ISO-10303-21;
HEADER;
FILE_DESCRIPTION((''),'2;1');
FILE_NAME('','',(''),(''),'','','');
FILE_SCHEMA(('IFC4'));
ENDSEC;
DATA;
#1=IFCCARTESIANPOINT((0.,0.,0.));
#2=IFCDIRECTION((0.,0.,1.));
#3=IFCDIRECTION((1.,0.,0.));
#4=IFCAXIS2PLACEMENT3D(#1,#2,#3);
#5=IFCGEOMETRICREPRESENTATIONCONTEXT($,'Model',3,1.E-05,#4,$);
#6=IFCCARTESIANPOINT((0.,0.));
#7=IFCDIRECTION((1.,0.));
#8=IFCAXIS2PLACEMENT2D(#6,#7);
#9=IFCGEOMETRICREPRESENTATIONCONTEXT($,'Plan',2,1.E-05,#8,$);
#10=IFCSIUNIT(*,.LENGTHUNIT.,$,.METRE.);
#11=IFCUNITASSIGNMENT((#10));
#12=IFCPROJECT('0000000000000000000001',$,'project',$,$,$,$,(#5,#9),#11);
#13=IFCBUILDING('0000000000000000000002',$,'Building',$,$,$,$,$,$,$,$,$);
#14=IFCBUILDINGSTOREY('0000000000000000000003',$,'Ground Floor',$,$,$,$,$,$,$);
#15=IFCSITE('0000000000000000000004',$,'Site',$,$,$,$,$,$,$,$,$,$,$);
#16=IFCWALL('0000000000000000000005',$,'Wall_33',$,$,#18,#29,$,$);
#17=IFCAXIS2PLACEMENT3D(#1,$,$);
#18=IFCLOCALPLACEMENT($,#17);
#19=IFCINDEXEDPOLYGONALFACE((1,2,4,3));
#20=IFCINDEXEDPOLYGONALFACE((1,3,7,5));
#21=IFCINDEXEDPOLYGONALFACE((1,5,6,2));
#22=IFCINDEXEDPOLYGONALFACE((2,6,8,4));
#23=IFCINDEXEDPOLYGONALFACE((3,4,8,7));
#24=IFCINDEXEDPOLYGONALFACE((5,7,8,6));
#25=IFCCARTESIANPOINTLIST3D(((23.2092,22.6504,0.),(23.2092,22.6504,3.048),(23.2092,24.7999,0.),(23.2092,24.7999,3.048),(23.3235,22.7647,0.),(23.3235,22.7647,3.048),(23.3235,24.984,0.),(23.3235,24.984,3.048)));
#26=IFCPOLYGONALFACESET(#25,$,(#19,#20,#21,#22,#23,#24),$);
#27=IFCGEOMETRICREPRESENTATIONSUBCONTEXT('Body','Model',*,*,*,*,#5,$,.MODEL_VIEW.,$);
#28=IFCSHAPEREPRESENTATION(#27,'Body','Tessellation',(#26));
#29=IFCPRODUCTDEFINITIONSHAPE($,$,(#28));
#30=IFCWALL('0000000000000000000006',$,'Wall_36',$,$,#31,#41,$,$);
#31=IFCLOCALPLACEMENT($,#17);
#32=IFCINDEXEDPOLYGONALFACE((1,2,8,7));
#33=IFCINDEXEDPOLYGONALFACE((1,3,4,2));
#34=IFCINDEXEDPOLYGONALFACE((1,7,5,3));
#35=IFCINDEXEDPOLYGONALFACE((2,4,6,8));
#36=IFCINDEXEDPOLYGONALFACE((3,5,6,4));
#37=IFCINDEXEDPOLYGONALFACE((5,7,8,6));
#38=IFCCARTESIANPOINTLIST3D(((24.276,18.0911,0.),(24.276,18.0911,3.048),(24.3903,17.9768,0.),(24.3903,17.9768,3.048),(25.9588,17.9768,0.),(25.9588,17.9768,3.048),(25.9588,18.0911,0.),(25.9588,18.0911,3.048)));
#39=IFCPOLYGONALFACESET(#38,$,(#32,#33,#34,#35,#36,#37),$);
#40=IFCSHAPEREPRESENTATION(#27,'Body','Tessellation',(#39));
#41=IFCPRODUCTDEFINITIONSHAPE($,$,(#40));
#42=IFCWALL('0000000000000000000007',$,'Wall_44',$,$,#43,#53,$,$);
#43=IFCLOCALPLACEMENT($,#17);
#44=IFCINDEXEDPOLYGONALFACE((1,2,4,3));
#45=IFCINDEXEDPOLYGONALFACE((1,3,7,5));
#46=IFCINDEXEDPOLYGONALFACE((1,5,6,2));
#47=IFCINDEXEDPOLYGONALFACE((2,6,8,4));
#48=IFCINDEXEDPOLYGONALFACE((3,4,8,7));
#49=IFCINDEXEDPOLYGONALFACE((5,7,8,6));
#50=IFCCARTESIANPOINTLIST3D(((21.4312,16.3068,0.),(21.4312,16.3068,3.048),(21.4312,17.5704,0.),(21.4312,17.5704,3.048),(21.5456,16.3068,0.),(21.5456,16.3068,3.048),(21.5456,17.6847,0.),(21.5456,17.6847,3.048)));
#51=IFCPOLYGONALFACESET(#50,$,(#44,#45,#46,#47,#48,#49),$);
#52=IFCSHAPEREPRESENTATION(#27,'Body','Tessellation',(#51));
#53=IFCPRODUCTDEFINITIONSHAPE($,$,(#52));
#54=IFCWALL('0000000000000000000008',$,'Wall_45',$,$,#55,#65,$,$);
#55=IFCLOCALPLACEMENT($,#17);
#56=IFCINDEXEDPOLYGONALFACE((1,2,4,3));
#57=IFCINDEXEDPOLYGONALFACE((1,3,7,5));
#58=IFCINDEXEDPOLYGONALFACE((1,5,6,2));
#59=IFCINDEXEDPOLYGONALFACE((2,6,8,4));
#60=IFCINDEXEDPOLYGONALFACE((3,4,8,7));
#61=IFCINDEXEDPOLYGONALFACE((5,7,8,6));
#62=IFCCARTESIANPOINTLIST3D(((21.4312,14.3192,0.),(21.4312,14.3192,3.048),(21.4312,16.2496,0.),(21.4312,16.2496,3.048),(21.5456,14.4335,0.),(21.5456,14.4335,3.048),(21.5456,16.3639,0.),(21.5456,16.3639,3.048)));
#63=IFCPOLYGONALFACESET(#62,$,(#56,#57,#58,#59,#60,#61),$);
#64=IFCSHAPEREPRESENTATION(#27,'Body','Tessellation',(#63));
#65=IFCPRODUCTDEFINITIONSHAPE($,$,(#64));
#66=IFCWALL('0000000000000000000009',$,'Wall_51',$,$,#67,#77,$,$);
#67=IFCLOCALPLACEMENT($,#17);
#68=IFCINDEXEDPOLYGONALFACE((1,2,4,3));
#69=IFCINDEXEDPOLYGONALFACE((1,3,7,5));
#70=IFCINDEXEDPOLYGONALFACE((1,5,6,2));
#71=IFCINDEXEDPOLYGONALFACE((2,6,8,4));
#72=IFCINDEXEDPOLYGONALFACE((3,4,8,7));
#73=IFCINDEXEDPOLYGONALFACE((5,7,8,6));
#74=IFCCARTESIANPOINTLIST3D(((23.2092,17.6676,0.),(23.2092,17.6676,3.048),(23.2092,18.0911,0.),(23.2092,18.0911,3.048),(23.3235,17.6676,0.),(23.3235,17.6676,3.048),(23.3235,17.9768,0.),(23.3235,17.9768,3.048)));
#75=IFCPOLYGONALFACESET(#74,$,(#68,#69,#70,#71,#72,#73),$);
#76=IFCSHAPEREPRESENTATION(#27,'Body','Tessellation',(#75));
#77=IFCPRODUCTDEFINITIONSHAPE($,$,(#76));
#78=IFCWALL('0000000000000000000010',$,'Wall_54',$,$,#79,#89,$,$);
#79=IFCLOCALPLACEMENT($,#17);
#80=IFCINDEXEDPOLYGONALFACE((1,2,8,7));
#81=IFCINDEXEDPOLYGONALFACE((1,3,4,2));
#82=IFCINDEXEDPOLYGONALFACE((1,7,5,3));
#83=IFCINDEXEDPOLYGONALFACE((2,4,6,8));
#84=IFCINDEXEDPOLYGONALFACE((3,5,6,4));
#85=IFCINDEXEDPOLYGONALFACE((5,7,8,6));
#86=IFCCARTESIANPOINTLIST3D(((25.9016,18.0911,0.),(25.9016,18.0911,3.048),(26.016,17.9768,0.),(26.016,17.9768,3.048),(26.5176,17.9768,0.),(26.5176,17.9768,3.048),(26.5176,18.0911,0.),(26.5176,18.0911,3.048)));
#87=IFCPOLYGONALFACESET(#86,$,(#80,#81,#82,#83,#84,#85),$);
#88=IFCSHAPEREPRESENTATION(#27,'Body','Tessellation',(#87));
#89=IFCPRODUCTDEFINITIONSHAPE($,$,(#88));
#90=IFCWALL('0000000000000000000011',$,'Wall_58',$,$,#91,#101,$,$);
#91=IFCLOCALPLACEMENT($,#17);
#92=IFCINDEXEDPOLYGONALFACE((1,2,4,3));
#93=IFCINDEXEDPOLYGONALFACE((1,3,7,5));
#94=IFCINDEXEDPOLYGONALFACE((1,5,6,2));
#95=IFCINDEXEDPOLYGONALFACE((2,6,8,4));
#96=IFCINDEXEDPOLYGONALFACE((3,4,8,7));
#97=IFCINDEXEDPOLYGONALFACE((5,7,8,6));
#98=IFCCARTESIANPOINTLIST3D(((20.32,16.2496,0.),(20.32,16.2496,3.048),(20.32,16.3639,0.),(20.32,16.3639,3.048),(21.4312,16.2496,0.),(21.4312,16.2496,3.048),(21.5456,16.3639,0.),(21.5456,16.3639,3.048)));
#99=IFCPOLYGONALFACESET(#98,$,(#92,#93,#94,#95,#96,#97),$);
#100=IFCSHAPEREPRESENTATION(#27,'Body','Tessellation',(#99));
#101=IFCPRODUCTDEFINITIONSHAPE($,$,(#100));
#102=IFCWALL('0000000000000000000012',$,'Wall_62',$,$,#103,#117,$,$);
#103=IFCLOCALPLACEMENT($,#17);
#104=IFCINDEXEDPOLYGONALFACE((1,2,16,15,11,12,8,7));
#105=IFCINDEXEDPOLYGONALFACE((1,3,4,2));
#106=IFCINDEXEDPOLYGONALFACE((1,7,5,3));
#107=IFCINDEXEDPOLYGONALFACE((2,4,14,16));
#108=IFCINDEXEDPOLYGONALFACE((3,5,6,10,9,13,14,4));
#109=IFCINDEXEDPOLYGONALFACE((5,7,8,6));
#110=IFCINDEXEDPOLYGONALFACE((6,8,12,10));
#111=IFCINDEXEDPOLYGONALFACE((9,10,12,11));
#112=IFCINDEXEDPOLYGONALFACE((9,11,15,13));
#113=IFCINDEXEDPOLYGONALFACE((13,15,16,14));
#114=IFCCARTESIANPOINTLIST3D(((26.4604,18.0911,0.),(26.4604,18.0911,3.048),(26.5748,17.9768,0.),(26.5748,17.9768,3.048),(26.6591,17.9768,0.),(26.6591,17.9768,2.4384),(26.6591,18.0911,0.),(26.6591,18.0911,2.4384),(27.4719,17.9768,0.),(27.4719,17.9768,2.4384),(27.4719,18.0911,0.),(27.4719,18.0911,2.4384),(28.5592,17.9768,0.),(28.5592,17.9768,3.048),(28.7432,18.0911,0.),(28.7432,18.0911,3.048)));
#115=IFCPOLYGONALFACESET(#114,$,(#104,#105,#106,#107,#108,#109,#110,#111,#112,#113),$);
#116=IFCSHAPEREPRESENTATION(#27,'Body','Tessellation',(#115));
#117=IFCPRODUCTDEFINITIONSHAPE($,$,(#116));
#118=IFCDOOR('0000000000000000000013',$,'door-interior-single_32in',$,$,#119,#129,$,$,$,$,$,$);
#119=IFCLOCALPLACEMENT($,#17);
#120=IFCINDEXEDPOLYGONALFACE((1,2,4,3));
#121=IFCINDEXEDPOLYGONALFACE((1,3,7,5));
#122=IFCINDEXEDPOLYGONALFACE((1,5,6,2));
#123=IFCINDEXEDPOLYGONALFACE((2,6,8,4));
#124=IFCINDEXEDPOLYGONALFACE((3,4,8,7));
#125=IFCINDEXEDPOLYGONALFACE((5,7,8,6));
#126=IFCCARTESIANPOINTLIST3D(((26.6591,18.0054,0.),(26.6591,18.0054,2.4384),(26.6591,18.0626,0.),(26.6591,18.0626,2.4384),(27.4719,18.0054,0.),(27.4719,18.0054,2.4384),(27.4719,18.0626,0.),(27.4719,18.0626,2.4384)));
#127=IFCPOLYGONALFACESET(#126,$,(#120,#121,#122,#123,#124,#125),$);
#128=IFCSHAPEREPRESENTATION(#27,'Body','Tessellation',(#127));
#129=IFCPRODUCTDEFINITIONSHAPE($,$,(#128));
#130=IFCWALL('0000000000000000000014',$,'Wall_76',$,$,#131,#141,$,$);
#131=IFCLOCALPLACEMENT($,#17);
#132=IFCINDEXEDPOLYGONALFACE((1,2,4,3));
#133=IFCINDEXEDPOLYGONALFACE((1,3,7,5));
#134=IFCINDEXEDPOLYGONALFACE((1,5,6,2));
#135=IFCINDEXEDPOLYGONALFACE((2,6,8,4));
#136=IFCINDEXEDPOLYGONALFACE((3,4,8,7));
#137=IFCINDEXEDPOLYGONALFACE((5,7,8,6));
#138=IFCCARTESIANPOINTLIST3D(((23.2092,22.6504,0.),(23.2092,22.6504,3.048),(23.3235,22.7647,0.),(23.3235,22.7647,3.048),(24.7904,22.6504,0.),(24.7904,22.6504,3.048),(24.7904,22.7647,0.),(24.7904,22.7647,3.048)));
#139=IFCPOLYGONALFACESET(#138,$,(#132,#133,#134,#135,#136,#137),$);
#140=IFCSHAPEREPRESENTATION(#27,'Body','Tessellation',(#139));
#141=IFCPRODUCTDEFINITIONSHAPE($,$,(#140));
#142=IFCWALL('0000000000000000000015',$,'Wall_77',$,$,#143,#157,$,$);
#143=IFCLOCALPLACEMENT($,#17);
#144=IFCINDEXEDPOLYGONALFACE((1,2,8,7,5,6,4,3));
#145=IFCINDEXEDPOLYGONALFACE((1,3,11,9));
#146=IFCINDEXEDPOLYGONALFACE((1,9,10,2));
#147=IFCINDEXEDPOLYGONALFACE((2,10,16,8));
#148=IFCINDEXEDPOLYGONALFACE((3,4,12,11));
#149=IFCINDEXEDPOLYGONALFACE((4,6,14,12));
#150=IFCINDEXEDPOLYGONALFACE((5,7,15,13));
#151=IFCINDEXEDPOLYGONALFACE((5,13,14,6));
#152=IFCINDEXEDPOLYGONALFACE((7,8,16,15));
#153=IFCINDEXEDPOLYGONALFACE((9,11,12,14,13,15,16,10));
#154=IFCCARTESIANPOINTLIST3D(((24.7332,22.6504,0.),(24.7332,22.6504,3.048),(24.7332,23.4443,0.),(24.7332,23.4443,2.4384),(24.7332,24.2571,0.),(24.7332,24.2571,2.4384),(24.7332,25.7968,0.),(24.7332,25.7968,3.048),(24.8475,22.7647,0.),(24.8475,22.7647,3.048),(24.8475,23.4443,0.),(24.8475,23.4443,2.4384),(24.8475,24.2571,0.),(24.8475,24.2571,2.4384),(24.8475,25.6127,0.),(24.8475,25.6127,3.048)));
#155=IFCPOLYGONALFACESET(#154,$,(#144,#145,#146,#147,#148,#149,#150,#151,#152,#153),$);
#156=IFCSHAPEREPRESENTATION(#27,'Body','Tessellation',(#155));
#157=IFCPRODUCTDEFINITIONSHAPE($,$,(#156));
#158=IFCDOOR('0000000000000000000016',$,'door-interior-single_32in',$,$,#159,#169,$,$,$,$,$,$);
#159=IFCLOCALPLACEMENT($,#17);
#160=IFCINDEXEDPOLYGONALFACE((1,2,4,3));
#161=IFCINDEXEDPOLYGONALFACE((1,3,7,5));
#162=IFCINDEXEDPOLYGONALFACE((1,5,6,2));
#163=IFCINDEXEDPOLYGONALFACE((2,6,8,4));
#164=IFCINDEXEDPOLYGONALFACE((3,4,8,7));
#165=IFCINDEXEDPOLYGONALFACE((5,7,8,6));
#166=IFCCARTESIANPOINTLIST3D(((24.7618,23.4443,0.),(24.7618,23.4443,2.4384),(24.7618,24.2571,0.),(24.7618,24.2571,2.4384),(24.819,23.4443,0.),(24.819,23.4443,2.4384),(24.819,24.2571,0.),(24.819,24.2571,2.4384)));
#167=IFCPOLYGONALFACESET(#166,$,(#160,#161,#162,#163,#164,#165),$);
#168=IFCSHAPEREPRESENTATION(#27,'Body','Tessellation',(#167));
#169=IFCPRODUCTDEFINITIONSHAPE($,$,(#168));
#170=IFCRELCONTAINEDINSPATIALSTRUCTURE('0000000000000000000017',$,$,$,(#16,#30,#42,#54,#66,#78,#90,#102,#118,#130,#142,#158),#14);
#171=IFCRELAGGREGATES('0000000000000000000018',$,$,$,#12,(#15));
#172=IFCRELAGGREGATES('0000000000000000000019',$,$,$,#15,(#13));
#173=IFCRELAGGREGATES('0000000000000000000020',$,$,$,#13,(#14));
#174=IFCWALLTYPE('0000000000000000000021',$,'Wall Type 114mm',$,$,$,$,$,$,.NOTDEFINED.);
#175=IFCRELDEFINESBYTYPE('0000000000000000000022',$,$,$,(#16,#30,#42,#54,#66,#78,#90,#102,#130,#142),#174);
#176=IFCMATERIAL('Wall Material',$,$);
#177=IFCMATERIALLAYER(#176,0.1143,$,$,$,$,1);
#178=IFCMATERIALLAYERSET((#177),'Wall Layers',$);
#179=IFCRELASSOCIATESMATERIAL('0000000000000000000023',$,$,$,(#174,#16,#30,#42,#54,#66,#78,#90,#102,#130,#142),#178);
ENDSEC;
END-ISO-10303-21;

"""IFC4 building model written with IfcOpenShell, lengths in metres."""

from ifc_helpers import new_model, si_unit, frame, origin_with_axes, origin_2d_with_axis, place, context, subcontext, project, spatial, line, indexed_curve, rectangle, outline, extrude, material, layer, layer_set, layer_usage, type_object, element, fill, save


model = new_model("IFC4")

# Units and contexts
model_context = context("Model", 3, precision=1e-05, world=origin_with_axes())
plan_context = context("Plan", 2, precision=1e-05, world=origin_2d_with_axis())
body_context = subcontext(model_context, "Body", "Model", "MODEL_VIEW")
ifc_project = project(units=[si_unit("LENGTHUNIT", "METRE")], contexts=[model_context, plan_context])

# Site, building, storey
site = spatial("IfcSite", under=ifc_project, Name="Site")
building = spatial("IfcBuilding", under=site, Name="Building")
storey = spatial("IfcBuildingStorey", under=building, Name="Ground Floor")

# Shared definitions
ifc_material_1 = material(Name="Wall Material")
ifc_layer_1 = layer(ifc_material_1, 0.1143, Priority=1)
ifc_layer_set_1 = layer_set([ifc_layer_1], Name="Wall Layers")
wall_type_1 = type_object("IfcWallType", Name="Wall Type 114mm", PredefinedType="NOTDEFINED", material=ifc_layer_set_1)

# Walls
ifc_layer_usage_1 = layer_usage(ifc_layer_set_1, "AXIS2", "POSITIVE", -0.0571)
wall_1_placement = place(None, frame((23.2664, 22.7076, 0.0), z_axis=(0.0, 0.0, 1.0), x_axis=(0.0, 1.0, 0.0)))
element("IfcWall", 1, at=wall_1_placement, inside=storey, type_object=wall_type_1, material=ifc_layer_usage_1, Name="Wall_33", context=body_context, shape_type="SweptSolid", body=[
    extrude(outline(indexed_curve([(0.0571, -0.0571), (-0.0571, 0.0571), (2.0924, 0.0571), (2.2765, -0.0571)], segments=[line(1, 2, 3, 4, 1)])), origin_with_axes(), (0.0, 0.0, 1.0), 3.048),
])
ifc_layer_usage_2 = layer_usage(ifc_layer_set_1, "AXIS2", "POSITIVE", -0.0571)
wall_2_placement = place(None, frame((25.9588, 18.034, 0.0), z_axis=(0.0, 0.0, 1.0), x_axis=(-1.0, 0.0, 0.0)))
element("IfcWall", 2, at=wall_2_placement, inside=storey, type_object=wall_type_1, material=ifc_layer_usage_2, Name="Wall_36", context=body_context, shape_type="SweptSolid", body=[
    extrude(outline(indexed_curve([(0.0, -0.0571), (0.0, 0.0571), (1.5685, 0.0571), (1.6828, -0.0571)], segments=[line(1, 2, 3, 4, 1)])), origin_with_axes(), (0.0, 0.0, 1.0), 3.048),
])
ifc_layer_usage_3 = layer_usage(ifc_layer_set_1, "AXIS2", "POSITIVE", -0.0571)
wall_3_placement = place(None, frame((21.4884, 17.6276, 0.0), z_axis=(0.0, 0.0, 1.0), x_axis=(0.0, -1.0, 0.0)))
element("IfcWall", 3, at=wall_3_placement, inside=storey, type_object=wall_type_1, material=ifc_layer_usage_3, Name="Wall_44", context=body_context, shape_type="SweptSolid", body=[
    extrude(outline(indexed_curve([(0.0571, -0.0571), (-0.0571, 0.0571), (1.3208, 0.0571), (1.3208, -0.0571)], segments=[line(1, 2, 3, 4, 1)])), origin_with_axes(), (0.0, 0.0, 1.0), 3.048),
])
ifc_layer_usage_4 = layer_usage(ifc_layer_set_1, "AXIS2", "POSITIVE", -0.0571)
wall_4_placement = place(None, frame((21.4884, 16.3068, 0.0), z_axis=(0.0, 0.0, 1.0), x_axis=(0.0, -1.0, 0.0)))
element("IfcWall", 4, at=wall_4_placement, inside=storey, type_object=wall_type_1, material=ifc_layer_usage_4, Name="Wall_45", context=body_context, shape_type="SweptSolid", body=[
    extrude(outline(indexed_curve([(0.0571, -0.0571), (-0.0571, 0.0571), (1.8733, 0.0571), (1.9876, -0.0571)], segments=[line(1, 2, 3, 4, 1)])), origin_with_axes(), (0.0, 0.0, 1.0), 3.048),
])
ifc_layer_usage_5 = layer_usage(ifc_layer_set_1, "AXIS2", "POSITIVE", -0.0571)
wall_5_placement = place(None, frame((23.2664, 17.6676, 0.0), z_axis=(0.0, 0.0, 1.0), x_axis=(0.0, 1.0, 0.0)))
element("IfcWall", 5, at=wall_5_placement, inside=storey, type_object=wall_type_1, material=ifc_layer_usage_5, Name="Wall_51", context=body_context, shape_type="SweptSolid", body=[
    extrude(outline(indexed_curve([(0.0, -0.0571), (0.0, 0.0571), (0.4235, 0.0571), (0.3092, -0.0571)], segments=[line(1, 2, 3, 4, 1)])), origin_with_axes(), (0.0, 0.0, 1.0), 3.048),
])
ifc_layer_usage_6 = layer_usage(ifc_layer_set_1, "AXIS2", "POSITIVE", -0.0571)
wall_6_placement = place(None, frame((26.5176, 18.034, 0.0), z_axis=(0.0, 0.0, 1.0), x_axis=(-1.0, 0.0, 0.0)))
element("IfcWall", 6, at=wall_6_placement, inside=storey, type_object=wall_type_1, material=ifc_layer_usage_6, Name="Wall_54", context=body_context, shape_type="SweptSolid", body=[
    extrude(outline(indexed_curve([(0.0, -0.0571), (0.0, 0.0571), (0.5016, 0.0571), (0.6159, -0.0571)], segments=[line(1, 2, 3, 4, 1)])), origin_with_axes(), (0.0, 0.0, 1.0), 3.048),
])
ifc_layer_usage_7 = layer_usage(ifc_layer_set_1, "AXIS2", "POSITIVE", -0.0571)
wall_7_placement = place(None, frame((21.4884, 16.3068, 0.0), z_axis=(0.0, 0.0, 1.0), x_axis=(-1.0, 0.0, 0.0)))
element("IfcWall", 7, at=wall_7_placement, inside=storey, type_object=wall_type_1, material=ifc_layer_usage_7, Name="Wall_58", context=body_context, shape_type="SweptSolid", body=[
    extrude(outline(indexed_curve([(-0.0571, -0.0571), (0.0571, 0.0571), (1.1684, 0.0571), (1.1684, -0.0571)], segments=[line(1, 2, 3, 4, 1)])), origin_with_axes(), (0.0, 0.0, 1.0), 3.048),
])

# Wall, opening, door
ifc_layer_usage_8 = layer_usage(ifc_layer_set_1, "AXIS2", "POSITIVE", -0.0571)
wall_8_placement = place(None, frame((28.6512, 18.034, 0.0), z_axis=(0.0, 0.0, 1.0), x_axis=(-1.0, 0.0, 0.0)))
wall_8 = element("IfcWall", 8, at=wall_8_placement, inside=storey, type_object=wall_type_1, material=ifc_layer_usage_8, Name="Wall_62", context=body_context, shape_type="SweptSolid", body=[
    extrude(outline(indexed_curve([(-0.092, -0.0571), (0.092, 0.0571), (2.0765, 0.0571), (2.1908, -0.0571)], segments=[line(1, 2, 3, 4, 1)])), origin_with_axes(), (0.0, 0.0, 1.0), 3.048),
])
opening_1_placement = place(wall_8_placement, frame((1.5857, 0.0, 0.0), z_axis=(0.0, 0.0, 1.0), x_axis=(1.0, 0.0, 0.0)))
opening_1 = element("IfcOpeningElement", 9, at=opening_1_placement, cuts=wall_8, context=body_context, shape_type="SweptSolid", body=[
    extrude(rectangle(XDim=0.8128, YDim=0.5), None, (0.0, 0.0, 1.0), 2.4384),
])
door_1_placement = place(None, frame((27.0655, 18.034, 0.0), z_axis=(0.0, 0.0, 1.0), x_axis=(1.0, 0.0, 0.0)))
door_1 = element("IfcDoor", 10, at=door_1_placement, inside=storey, Name="door-interior-single_32in", context=body_context, shape_type="SweptSolid", body=[
    extrude(rectangle(XDim=0.8128, YDim=0.0571), None, (0.0, 0.0, 1.0), 2.4384),
])
fill(opening_1, door_1)

# Wall
ifc_layer_usage_9 = layer_usage(ifc_layer_set_1, "AXIS2", "POSITIVE", -0.0571)
wall_9_placement = place(None, frame((23.2664, 22.7076, 0.0), z_axis=(0.0, 0.0, 1.0), x_axis=(1.0, 0.0, 0.0)))
element("IfcWall", 11, at=wall_9_placement, inside=storey, type_object=wall_type_1, material=ifc_layer_usage_9, Name="Wall_76", context=body_context, shape_type="SweptSolid", body=[
    extrude(outline(indexed_curve([(-0.0571, -0.0571), (0.0571, 0.0571), (1.524, 0.0571), (1.524, -0.0571)], segments=[line(1, 2, 3, 4, 1)])), origin_with_axes(), (0.0, 0.0, 1.0), 3.048),
])

# Wall, opening, door
ifc_layer_usage_10 = layer_usage(ifc_layer_set_1, "AXIS2", "POSITIVE", -0.0571)
wall_10_placement = place(None, frame((24.7904, 22.7076, 0.0), z_axis=(0.0, 0.0, 1.0), x_axis=(0.0, 1.0, 0.0)))
wall_10 = element("IfcWall", 12, at=wall_10_placement, inside=storey, type_object=wall_type_1, material=ifc_layer_usage_10, Name="Wall_77", context=body_context, shape_type="SweptSolid", body=[
    extrude(outline(indexed_curve([(0.0571, -0.0571), (-0.0571, 0.0571), (3.0892, 0.0571), (2.9051, -0.0571)], segments=[line(1, 2, 3, 4, 1)])), origin_with_axes(), (0.0, 0.0, 1.0), 3.048),
])
opening_2_placement = place(wall_10_placement, frame((1.1431, 0.0, 0.0), z_axis=(0.0, 0.0, 1.0), x_axis=(1.0, 0.0, 0.0)))
opening_2 = element("IfcOpeningElement", 13, at=opening_2_placement, cuts=wall_10, context=body_context, shape_type="SweptSolid", body=[
    extrude(rectangle(XDim=0.8128, YDim=0.5), None, (0.0, 0.0, 1.0), 2.4384),
])
door_2_placement = place(None, frame((24.7904, 23.8507, 0.0), z_axis=(0.0, 0.0, 1.0), x_axis=(0.0, -1.0, 0.0)))
door_2 = element("IfcDoor", 14, at=door_2_placement, inside=storey, Name="door-interior-single_32in", context=body_context, shape_type="SweptSolid", body=[
    extrude(rectangle(XDim=0.8128, YDim=0.0571), None, (0.0, 0.0, 1.0), 2.4384),
])
fill(opening_2, door_2)

save(model, "model.ifc")
